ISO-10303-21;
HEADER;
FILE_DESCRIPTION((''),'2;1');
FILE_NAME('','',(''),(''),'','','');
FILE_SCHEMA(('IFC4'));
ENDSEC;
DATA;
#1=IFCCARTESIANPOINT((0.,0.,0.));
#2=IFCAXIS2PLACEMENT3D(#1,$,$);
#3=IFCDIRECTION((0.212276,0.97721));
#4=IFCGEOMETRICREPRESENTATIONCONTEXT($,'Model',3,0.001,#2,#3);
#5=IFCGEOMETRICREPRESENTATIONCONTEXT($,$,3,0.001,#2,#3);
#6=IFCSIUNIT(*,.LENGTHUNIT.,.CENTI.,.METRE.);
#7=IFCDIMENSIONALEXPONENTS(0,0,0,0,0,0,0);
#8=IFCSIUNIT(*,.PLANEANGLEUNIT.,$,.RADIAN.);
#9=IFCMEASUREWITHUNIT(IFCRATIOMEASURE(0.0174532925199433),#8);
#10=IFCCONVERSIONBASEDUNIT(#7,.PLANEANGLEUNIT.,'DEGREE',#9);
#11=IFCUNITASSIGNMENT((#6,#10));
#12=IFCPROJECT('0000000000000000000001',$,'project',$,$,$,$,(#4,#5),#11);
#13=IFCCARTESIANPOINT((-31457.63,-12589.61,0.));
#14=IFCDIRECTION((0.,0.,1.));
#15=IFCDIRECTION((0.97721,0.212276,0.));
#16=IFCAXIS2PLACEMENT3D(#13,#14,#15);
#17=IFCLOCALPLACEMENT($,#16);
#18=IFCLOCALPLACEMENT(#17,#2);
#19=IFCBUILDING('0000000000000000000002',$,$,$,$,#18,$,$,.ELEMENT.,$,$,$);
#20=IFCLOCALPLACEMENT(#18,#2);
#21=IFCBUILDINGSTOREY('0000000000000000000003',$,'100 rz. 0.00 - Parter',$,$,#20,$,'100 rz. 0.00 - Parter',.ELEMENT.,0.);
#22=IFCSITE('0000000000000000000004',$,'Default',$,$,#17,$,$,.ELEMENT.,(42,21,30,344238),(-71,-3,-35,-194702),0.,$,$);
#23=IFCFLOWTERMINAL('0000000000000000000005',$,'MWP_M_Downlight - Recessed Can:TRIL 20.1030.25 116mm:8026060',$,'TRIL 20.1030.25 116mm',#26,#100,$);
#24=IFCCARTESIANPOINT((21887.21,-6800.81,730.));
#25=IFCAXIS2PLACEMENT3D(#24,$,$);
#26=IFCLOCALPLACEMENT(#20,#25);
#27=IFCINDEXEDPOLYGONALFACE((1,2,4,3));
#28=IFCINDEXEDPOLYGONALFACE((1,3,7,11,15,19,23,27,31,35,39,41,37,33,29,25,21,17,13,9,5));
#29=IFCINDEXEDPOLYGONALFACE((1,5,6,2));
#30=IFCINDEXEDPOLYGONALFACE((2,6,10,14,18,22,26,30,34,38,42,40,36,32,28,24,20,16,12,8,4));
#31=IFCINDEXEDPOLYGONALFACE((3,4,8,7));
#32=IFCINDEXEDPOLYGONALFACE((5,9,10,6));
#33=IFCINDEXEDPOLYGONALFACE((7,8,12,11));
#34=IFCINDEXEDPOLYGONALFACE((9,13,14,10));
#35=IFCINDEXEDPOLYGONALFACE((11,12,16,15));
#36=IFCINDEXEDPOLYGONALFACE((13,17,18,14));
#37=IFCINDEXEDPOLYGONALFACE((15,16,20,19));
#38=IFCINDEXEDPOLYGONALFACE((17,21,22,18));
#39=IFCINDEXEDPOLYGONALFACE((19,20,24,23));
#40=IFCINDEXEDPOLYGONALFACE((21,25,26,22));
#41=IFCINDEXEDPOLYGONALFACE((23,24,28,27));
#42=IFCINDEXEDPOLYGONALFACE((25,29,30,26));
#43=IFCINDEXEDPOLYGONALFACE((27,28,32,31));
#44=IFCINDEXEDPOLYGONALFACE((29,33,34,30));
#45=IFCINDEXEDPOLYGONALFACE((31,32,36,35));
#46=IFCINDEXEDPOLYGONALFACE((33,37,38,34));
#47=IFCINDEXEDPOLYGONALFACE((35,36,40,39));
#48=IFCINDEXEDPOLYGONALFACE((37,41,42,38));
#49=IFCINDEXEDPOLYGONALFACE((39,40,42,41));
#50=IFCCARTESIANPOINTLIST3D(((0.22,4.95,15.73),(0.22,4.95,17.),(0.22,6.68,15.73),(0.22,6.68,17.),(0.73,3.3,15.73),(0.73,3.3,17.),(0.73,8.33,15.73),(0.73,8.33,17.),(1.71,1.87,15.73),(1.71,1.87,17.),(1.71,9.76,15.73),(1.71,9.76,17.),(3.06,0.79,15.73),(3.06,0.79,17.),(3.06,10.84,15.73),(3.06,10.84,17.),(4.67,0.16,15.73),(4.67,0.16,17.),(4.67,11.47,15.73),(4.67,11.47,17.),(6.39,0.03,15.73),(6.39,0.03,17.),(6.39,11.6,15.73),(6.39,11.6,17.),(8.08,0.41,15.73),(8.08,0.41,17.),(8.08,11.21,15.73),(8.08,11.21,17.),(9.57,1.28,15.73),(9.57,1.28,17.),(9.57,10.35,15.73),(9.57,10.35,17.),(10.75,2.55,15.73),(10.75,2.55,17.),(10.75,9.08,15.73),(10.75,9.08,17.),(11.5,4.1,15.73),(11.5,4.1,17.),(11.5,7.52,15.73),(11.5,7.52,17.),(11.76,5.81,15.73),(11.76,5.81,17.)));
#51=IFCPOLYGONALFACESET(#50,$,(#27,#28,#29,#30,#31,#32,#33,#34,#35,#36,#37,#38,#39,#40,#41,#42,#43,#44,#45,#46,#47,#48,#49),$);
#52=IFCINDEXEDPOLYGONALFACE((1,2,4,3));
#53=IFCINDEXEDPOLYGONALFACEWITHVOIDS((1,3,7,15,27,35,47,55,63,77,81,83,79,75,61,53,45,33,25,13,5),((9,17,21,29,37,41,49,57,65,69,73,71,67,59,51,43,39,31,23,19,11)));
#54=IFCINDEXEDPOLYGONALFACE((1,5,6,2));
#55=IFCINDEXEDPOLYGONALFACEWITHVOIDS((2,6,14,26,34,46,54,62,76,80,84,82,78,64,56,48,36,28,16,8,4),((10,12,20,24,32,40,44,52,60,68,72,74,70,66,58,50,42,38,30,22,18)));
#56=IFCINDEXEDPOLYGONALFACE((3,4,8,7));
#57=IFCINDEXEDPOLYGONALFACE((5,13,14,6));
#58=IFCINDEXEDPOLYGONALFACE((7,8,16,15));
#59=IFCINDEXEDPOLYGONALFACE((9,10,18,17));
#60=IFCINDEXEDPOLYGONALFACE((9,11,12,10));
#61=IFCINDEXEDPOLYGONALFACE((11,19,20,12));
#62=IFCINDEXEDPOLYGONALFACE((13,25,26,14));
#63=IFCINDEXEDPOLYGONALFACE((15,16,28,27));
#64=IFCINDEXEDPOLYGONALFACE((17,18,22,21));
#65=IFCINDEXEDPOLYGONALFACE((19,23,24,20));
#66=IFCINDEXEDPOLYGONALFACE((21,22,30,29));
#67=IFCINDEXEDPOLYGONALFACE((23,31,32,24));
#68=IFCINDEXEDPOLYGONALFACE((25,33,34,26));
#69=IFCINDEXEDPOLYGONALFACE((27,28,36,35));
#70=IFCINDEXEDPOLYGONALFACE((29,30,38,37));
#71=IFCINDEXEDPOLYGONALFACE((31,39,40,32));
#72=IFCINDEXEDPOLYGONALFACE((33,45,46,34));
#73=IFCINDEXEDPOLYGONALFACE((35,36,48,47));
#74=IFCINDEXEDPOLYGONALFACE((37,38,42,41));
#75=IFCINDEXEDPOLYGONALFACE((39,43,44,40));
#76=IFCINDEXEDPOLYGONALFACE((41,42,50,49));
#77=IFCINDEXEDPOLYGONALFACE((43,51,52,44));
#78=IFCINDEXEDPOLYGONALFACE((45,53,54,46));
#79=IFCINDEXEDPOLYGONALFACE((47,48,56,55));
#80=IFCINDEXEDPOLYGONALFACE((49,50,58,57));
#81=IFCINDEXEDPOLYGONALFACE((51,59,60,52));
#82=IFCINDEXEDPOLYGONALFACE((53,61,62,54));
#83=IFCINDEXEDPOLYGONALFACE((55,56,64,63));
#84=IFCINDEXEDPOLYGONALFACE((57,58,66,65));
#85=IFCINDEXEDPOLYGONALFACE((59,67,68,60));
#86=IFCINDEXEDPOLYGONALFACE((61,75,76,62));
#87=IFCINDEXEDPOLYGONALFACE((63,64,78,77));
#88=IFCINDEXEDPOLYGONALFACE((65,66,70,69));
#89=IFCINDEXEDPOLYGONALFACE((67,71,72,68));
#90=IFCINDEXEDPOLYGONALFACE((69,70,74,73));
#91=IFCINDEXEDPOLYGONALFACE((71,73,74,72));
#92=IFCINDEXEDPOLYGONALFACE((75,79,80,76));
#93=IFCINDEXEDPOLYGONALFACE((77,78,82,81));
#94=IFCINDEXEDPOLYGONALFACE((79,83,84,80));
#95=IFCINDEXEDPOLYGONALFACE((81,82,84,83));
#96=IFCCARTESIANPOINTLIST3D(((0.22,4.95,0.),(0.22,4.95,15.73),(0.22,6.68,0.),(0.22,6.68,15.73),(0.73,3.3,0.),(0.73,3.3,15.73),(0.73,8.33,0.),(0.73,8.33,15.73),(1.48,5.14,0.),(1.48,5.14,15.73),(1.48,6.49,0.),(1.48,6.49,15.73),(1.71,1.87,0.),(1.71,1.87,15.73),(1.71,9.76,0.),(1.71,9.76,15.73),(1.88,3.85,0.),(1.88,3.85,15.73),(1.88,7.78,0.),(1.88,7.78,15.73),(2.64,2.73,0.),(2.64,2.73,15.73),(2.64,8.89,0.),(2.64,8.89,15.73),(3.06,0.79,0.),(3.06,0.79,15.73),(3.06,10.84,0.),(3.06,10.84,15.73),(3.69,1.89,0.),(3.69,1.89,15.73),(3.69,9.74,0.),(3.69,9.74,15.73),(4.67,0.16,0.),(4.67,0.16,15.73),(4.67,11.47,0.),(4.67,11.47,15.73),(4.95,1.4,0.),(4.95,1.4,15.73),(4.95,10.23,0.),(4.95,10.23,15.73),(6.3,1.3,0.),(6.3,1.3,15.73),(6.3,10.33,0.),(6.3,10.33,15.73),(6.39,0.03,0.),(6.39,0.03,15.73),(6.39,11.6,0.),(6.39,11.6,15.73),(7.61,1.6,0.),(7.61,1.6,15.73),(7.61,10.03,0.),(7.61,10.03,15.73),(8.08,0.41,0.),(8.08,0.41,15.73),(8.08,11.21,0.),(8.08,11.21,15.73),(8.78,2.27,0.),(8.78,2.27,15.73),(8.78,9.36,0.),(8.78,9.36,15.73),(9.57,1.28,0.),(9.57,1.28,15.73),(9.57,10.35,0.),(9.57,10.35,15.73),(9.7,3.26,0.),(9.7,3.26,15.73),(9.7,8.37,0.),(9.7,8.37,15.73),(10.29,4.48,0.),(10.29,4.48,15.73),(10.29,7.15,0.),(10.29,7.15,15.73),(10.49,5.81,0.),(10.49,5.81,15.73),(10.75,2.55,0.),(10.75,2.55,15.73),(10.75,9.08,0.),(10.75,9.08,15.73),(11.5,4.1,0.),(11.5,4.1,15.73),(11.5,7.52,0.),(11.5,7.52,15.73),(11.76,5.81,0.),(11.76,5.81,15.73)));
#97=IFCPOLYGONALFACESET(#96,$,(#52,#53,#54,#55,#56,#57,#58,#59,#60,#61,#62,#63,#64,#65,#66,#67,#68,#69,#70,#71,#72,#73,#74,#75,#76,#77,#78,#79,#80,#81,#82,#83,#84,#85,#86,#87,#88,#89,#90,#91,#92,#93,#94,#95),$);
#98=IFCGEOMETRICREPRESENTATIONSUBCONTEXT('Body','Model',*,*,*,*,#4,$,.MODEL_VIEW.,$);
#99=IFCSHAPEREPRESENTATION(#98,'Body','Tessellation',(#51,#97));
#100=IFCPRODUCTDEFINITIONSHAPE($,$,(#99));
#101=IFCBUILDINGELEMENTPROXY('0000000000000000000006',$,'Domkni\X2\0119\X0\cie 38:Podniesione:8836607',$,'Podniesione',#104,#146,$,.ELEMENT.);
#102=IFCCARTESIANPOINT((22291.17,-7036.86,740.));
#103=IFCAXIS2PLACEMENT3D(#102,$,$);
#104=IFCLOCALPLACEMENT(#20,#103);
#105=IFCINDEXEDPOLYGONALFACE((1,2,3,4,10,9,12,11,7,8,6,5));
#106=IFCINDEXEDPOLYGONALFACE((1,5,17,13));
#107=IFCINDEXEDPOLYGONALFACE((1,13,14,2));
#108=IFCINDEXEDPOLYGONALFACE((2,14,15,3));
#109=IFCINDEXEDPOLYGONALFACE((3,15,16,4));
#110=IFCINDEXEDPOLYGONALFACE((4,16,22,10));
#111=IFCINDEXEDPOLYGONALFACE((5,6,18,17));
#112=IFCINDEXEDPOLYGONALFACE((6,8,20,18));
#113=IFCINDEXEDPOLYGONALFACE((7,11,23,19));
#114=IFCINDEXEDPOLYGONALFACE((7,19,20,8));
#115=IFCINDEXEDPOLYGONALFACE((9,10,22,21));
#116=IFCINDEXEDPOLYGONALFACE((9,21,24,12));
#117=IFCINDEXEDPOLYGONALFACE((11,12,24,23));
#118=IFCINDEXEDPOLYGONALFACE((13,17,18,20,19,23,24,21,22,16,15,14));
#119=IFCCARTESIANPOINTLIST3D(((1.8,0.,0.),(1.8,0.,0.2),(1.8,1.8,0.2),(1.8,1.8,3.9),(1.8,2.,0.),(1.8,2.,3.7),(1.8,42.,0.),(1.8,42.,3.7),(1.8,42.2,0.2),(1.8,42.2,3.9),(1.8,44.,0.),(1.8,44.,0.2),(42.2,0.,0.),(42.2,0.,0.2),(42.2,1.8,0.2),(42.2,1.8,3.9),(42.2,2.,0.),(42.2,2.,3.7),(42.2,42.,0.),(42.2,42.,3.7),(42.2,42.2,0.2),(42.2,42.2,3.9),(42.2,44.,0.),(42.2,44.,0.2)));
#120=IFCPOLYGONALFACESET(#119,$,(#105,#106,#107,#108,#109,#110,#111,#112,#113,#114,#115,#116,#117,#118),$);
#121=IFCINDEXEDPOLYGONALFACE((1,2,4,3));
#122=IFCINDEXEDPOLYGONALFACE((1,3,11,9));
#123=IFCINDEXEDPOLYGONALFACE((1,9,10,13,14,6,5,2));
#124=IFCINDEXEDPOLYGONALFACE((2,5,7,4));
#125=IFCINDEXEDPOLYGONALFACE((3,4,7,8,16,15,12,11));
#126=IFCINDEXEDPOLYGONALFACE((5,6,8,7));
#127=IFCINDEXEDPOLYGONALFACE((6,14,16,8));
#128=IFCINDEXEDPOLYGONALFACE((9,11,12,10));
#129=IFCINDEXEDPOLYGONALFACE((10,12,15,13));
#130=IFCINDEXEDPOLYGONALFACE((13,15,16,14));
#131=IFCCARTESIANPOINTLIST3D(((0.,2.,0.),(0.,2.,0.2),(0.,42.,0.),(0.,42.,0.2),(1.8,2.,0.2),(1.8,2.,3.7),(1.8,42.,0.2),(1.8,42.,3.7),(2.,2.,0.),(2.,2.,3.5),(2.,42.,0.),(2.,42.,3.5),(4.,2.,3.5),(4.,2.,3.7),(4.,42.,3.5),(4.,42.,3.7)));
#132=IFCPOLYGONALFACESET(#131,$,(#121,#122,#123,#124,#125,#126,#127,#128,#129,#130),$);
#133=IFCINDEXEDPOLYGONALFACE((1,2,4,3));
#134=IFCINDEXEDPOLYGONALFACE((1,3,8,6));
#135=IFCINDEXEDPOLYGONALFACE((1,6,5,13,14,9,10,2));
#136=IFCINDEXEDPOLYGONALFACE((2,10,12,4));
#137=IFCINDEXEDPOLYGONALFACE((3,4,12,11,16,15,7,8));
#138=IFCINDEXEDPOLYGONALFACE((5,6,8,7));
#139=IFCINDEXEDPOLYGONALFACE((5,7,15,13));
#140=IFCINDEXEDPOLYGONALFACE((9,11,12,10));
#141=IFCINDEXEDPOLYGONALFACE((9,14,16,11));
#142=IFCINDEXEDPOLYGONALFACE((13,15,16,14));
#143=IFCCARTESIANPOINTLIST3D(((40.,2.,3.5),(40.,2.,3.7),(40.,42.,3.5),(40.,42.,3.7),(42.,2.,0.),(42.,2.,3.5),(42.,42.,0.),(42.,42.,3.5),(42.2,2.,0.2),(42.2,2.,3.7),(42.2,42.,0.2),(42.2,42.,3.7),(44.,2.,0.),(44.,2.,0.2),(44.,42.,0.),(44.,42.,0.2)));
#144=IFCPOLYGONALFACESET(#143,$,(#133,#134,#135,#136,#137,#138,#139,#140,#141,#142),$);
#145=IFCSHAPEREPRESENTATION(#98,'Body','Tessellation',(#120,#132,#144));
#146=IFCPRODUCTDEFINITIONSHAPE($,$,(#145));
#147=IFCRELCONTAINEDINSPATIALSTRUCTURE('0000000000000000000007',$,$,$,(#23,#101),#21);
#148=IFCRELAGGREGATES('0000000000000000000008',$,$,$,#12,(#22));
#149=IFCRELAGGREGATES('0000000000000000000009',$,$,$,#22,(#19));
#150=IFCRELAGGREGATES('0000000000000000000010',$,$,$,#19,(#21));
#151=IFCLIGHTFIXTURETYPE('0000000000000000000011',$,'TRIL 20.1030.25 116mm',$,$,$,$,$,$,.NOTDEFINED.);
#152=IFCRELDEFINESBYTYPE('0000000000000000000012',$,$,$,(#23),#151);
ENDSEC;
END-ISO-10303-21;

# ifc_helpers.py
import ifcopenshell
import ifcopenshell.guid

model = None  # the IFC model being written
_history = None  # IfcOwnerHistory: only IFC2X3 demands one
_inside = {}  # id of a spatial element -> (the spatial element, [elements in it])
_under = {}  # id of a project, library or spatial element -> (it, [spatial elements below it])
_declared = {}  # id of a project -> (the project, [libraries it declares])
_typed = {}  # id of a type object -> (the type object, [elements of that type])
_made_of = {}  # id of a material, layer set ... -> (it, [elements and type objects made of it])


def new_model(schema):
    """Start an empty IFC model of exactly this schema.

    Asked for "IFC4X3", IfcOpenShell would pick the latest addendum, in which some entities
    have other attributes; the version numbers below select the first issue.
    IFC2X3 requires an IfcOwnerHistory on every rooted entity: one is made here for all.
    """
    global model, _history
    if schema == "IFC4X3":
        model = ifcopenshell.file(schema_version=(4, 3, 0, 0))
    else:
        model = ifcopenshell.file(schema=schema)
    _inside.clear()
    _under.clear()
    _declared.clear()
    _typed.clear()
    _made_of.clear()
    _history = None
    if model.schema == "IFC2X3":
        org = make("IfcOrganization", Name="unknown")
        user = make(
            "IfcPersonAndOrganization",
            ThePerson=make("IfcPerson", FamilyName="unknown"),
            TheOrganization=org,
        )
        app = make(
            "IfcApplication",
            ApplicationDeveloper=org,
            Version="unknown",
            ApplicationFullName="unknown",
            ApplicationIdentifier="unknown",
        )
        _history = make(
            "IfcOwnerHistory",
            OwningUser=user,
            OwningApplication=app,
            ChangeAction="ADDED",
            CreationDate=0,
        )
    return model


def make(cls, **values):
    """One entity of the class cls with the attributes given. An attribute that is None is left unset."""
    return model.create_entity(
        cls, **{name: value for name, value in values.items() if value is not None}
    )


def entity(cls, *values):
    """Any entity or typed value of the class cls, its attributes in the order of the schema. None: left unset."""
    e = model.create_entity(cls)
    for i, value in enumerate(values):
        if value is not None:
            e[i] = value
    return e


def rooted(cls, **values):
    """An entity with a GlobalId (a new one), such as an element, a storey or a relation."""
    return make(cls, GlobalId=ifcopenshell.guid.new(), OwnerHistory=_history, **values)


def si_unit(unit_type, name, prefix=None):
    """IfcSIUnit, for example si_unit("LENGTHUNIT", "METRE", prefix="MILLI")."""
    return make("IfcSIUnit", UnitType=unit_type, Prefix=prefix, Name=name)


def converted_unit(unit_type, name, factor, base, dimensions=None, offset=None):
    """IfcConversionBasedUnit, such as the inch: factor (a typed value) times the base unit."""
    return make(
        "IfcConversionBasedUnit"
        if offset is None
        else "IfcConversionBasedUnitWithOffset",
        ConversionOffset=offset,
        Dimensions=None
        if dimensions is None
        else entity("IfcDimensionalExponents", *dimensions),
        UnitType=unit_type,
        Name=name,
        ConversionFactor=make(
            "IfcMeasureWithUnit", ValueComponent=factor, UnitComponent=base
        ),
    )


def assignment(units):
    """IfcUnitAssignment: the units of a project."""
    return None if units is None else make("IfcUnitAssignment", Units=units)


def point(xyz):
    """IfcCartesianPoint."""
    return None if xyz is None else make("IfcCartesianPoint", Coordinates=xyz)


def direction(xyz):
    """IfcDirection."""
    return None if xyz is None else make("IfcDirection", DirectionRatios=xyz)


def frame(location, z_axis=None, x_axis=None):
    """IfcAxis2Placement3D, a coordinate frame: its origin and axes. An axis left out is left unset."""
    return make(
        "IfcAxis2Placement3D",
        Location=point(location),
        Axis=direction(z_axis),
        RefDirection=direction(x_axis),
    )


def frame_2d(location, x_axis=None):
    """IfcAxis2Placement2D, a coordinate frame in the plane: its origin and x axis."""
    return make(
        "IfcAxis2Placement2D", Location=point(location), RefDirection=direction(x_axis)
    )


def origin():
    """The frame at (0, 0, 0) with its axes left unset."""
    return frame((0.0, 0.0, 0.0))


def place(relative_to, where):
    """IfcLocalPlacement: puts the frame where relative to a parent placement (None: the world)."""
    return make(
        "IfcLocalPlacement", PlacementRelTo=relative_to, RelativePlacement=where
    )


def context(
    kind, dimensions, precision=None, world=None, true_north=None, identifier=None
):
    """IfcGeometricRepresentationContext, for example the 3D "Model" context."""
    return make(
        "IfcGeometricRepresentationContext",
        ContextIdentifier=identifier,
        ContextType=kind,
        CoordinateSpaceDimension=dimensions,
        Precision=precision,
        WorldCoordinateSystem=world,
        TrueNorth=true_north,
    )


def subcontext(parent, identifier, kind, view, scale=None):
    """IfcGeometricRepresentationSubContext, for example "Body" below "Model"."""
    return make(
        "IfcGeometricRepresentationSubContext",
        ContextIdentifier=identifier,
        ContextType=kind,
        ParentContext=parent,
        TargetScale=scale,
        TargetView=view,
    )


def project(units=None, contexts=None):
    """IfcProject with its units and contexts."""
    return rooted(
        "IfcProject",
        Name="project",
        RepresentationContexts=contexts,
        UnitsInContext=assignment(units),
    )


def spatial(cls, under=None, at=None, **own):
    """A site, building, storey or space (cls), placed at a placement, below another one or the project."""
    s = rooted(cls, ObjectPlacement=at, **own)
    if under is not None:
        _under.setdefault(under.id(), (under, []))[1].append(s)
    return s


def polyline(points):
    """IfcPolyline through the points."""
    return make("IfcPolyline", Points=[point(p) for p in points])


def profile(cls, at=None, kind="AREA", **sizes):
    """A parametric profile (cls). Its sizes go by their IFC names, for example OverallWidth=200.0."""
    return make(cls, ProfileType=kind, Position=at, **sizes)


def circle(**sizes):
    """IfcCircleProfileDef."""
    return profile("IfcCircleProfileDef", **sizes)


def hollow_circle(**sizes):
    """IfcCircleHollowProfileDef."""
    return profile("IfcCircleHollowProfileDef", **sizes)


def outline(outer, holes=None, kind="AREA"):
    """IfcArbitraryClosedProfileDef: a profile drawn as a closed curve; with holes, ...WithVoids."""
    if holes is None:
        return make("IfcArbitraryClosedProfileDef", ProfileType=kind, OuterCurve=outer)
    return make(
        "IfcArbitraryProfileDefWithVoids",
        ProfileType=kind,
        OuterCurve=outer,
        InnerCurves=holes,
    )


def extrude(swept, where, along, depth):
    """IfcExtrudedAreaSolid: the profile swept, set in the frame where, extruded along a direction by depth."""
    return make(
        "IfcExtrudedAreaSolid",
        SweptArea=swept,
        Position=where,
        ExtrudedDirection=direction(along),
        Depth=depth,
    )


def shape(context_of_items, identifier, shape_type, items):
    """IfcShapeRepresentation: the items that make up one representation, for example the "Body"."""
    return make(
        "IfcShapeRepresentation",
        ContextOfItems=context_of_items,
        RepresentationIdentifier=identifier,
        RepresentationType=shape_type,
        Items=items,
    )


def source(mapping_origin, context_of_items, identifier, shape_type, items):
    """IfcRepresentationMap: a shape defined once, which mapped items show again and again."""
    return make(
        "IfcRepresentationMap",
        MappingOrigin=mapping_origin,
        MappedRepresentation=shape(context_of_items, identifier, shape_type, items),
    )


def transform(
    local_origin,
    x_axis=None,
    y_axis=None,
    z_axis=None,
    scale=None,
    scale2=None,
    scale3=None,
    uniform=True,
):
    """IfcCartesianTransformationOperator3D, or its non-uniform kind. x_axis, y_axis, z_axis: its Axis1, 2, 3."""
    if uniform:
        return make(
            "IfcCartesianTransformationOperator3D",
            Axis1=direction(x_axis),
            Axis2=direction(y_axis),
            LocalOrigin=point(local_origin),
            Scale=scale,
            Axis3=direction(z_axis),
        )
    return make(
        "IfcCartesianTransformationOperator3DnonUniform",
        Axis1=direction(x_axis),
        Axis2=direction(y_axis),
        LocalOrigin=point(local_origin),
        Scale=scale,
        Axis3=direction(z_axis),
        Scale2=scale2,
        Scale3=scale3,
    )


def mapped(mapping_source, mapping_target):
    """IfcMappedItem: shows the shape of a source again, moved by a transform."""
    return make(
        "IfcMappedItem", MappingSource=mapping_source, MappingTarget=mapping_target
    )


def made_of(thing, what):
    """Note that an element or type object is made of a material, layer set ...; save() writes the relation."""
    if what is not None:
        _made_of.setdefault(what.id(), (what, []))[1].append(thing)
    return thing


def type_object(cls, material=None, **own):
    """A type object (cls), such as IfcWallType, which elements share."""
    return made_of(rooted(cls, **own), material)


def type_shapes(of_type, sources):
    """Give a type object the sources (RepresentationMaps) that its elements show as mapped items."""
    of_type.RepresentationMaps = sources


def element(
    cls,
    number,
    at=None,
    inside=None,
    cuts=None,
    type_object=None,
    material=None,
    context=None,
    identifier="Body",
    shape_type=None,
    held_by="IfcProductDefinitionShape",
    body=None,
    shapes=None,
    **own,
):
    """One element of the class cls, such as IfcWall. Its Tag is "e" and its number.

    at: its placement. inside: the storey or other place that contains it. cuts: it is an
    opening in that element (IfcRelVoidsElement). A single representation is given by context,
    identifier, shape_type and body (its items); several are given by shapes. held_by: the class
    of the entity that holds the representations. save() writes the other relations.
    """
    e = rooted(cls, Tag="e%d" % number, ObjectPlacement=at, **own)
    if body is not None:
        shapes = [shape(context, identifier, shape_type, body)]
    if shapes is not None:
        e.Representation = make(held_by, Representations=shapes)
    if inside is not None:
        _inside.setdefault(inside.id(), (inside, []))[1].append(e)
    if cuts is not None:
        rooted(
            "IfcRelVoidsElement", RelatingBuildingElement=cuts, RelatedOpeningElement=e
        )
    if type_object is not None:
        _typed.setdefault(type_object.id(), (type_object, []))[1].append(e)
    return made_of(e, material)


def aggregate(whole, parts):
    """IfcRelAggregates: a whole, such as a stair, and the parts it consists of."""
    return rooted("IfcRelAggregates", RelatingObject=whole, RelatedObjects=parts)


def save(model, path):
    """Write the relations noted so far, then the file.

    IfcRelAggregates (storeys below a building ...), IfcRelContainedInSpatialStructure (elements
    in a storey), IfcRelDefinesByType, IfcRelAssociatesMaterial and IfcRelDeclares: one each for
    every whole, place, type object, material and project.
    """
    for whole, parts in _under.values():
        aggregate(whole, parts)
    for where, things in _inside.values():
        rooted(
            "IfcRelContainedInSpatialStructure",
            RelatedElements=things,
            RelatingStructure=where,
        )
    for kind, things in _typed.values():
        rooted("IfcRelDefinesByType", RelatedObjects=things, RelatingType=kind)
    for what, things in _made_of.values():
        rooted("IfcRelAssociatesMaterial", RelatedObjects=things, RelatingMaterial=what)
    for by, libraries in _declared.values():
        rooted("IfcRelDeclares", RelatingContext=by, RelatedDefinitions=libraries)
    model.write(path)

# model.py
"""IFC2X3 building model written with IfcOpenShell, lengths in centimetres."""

from ifc_helpers import new_model, entity, si_unit, converted_unit, direction, frame, frame_2d, origin, place, context, subcontext, project, spatial, polyline, circle, hollow_circle, outline, extrude, source, transform, mapped, type_object, type_shapes, element, save


model = new_model("IFC2X3")

# Units and contexts
model_context = context("Model", 3, precision=0.001, world=origin(), true_north=direction((0.212276, 0.97721)))
context_of_model = context(None, 3, precision=0.001, world=origin(), true_north=direction((0.212276, 0.97721)))
body_context = subcontext(model_context, "Body", "Model", "MODEL_VIEW")
ifc_project = project(units=[si_unit("LENGTHUNIT", "METRE", prefix="CENTI"), converted_unit("PLANEANGLEUNIT", "DEGREE", entity("IfcRatioMeasure", 0.0174532925199433), si_unit("PLANEANGLEUNIT", "RADIAN"), dimensions=[0, 0, 0, 0, 0, 0, 0])], contexts=[model_context, context_of_model])

# Site, building, storey
site_placement = place(None, frame((-31457.63, -12589.61, 0.0), z_axis=(0.0, 0.0, 1.0), x_axis=(0.97721, 0.212276, 0.0)))
site = spatial("IfcSite", under=ifc_project, at=site_placement, Name="Default", CompositionType="ELEMENT", RefLatitude=(42, 21, 30, 344238), RefLongitude=(-71, -3, -35, -194702), RefElevation=0.0)
building_placement = place(site_placement, origin())
building = spatial("IfcBuilding", under=site, at=building_placement, CompositionType="ELEMENT")
storey_placement = place(building_placement, origin())
storey = spatial("IfcBuildingStorey", under=building, at=storey_placement, Name="100 rz. 0.00 - Parter", LongName="100 rz. 0.00 - Parter", CompositionType="ELEMENT", Elevation=0.0)

# Flow terminal
light_fixture_type_1 = type_object("IfcLightFixtureType", Name="TRIL 20.1030.25 116mm", PredefinedType="NOTDEFINED")
shared_shape_1 = source(origin(), body_context, "Body", "SweptSolid", [
    extrude(circle(Radius=5.8, at=frame_2d((0.0, 0.0), x_axis=(1.0, 0.0))), frame((5.96, 5.81, 15.73)), (0.0, 0.0, 1.0), 1.27),
    extrude(hollow_circle(Radius=5.8, WallThickness=1.27, at=frame_2d((0.0, 0.0), x_axis=(1.0, 0.0))), frame((5.96, 5.81, 0.0)), (0.0, 0.0, 1.0), 15.73),
])
type_shapes(light_fixture_type_1, [shared_shape_1])
flow_terminal_placement = place(storey_placement, frame((21887.21, -6800.81, 730.0)))
element("IfcFlowTerminal", 1, at=flow_terminal_placement, inside=storey, type_object=light_fixture_type_1, Name="MWP_M_Downlight - Recessed Can:TRIL 20.1030.25 116mm:8026060", ObjectType="TRIL 20.1030.25 116mm", context=body_context, shape_type="MappedRepresentation", body=[
    mapped(shared_shape_1, transform((0.0, 0.0, 0.0), scale=1.0)),
])

# Building element proxy
shared_shape_2 = source(origin(), body_context, "Body", "SweptSolid", [
    extrude(outline(polyline([(-2.37, 20.0), (1.33, 20.0), (1.33, 22.0), (1.13, 22.0), (1.13, 20.2), (-2.57, 20.2), (-2.57, -20.2), (1.13, -20.2), (1.13, -22.0), (1.33, -22.0), (1.33, -20.0), (-2.37, -20.0), (-2.37, 20.0)])), frame((1.8, 22.0, 1.33), z_axis=(1.0, 0.0, 0.0), x_axis=(0.0, 0.0, -1.0)), (0.0, 0.0, 1.0), 40.4),
    extrude(outline(polyline([(-1.65, -0.05), (1.85, -0.05), (1.85, 1.95), (1.65, 1.95), (1.65, 0.15), (-1.85, 0.15), (-1.85, -2.05), (-1.65, -2.05), (-1.65, -0.05)])), frame((1.95, 2.0, 1.85), z_axis=(0.0, 1.0, 0.0), x_axis=(0.0, 0.0, -1.0)), (0.0, 0.0, 1.0), 40.0),
    extrude(outline(polyline([(0.05, 1.65), (2.05, 1.65), (2.05, 1.85), (-0.15, 1.85), (-0.15, -1.65), (-1.95, -1.65), (-1.95, -1.85), (0.05, -1.85), (0.05, 1.65)])), frame((42.05, 2.0, 1.85), z_axis=(0.0, 1.0, 0.0), x_axis=(-1.0, 0.0, 0.0)), (0.0, 0.0, 1.0), 40.0),
])
proxy_1_placement = place(storey_placement, frame((22291.17, -7036.86, 740.0)))
element("IfcBuildingElementProxy", 2, at=proxy_1_placement, inside=storey, Name="Domknięcie 38:Podniesione:8836607", ObjectType="Podniesione", CompositionType="ELEMENT", context=body_context, shape_type="MappedRepresentation", body=[
    mapped(shared_shape_2, transform((0.0, 0.0, 0.0), scale=1.0)),
])

save(model, "model.ifc")
